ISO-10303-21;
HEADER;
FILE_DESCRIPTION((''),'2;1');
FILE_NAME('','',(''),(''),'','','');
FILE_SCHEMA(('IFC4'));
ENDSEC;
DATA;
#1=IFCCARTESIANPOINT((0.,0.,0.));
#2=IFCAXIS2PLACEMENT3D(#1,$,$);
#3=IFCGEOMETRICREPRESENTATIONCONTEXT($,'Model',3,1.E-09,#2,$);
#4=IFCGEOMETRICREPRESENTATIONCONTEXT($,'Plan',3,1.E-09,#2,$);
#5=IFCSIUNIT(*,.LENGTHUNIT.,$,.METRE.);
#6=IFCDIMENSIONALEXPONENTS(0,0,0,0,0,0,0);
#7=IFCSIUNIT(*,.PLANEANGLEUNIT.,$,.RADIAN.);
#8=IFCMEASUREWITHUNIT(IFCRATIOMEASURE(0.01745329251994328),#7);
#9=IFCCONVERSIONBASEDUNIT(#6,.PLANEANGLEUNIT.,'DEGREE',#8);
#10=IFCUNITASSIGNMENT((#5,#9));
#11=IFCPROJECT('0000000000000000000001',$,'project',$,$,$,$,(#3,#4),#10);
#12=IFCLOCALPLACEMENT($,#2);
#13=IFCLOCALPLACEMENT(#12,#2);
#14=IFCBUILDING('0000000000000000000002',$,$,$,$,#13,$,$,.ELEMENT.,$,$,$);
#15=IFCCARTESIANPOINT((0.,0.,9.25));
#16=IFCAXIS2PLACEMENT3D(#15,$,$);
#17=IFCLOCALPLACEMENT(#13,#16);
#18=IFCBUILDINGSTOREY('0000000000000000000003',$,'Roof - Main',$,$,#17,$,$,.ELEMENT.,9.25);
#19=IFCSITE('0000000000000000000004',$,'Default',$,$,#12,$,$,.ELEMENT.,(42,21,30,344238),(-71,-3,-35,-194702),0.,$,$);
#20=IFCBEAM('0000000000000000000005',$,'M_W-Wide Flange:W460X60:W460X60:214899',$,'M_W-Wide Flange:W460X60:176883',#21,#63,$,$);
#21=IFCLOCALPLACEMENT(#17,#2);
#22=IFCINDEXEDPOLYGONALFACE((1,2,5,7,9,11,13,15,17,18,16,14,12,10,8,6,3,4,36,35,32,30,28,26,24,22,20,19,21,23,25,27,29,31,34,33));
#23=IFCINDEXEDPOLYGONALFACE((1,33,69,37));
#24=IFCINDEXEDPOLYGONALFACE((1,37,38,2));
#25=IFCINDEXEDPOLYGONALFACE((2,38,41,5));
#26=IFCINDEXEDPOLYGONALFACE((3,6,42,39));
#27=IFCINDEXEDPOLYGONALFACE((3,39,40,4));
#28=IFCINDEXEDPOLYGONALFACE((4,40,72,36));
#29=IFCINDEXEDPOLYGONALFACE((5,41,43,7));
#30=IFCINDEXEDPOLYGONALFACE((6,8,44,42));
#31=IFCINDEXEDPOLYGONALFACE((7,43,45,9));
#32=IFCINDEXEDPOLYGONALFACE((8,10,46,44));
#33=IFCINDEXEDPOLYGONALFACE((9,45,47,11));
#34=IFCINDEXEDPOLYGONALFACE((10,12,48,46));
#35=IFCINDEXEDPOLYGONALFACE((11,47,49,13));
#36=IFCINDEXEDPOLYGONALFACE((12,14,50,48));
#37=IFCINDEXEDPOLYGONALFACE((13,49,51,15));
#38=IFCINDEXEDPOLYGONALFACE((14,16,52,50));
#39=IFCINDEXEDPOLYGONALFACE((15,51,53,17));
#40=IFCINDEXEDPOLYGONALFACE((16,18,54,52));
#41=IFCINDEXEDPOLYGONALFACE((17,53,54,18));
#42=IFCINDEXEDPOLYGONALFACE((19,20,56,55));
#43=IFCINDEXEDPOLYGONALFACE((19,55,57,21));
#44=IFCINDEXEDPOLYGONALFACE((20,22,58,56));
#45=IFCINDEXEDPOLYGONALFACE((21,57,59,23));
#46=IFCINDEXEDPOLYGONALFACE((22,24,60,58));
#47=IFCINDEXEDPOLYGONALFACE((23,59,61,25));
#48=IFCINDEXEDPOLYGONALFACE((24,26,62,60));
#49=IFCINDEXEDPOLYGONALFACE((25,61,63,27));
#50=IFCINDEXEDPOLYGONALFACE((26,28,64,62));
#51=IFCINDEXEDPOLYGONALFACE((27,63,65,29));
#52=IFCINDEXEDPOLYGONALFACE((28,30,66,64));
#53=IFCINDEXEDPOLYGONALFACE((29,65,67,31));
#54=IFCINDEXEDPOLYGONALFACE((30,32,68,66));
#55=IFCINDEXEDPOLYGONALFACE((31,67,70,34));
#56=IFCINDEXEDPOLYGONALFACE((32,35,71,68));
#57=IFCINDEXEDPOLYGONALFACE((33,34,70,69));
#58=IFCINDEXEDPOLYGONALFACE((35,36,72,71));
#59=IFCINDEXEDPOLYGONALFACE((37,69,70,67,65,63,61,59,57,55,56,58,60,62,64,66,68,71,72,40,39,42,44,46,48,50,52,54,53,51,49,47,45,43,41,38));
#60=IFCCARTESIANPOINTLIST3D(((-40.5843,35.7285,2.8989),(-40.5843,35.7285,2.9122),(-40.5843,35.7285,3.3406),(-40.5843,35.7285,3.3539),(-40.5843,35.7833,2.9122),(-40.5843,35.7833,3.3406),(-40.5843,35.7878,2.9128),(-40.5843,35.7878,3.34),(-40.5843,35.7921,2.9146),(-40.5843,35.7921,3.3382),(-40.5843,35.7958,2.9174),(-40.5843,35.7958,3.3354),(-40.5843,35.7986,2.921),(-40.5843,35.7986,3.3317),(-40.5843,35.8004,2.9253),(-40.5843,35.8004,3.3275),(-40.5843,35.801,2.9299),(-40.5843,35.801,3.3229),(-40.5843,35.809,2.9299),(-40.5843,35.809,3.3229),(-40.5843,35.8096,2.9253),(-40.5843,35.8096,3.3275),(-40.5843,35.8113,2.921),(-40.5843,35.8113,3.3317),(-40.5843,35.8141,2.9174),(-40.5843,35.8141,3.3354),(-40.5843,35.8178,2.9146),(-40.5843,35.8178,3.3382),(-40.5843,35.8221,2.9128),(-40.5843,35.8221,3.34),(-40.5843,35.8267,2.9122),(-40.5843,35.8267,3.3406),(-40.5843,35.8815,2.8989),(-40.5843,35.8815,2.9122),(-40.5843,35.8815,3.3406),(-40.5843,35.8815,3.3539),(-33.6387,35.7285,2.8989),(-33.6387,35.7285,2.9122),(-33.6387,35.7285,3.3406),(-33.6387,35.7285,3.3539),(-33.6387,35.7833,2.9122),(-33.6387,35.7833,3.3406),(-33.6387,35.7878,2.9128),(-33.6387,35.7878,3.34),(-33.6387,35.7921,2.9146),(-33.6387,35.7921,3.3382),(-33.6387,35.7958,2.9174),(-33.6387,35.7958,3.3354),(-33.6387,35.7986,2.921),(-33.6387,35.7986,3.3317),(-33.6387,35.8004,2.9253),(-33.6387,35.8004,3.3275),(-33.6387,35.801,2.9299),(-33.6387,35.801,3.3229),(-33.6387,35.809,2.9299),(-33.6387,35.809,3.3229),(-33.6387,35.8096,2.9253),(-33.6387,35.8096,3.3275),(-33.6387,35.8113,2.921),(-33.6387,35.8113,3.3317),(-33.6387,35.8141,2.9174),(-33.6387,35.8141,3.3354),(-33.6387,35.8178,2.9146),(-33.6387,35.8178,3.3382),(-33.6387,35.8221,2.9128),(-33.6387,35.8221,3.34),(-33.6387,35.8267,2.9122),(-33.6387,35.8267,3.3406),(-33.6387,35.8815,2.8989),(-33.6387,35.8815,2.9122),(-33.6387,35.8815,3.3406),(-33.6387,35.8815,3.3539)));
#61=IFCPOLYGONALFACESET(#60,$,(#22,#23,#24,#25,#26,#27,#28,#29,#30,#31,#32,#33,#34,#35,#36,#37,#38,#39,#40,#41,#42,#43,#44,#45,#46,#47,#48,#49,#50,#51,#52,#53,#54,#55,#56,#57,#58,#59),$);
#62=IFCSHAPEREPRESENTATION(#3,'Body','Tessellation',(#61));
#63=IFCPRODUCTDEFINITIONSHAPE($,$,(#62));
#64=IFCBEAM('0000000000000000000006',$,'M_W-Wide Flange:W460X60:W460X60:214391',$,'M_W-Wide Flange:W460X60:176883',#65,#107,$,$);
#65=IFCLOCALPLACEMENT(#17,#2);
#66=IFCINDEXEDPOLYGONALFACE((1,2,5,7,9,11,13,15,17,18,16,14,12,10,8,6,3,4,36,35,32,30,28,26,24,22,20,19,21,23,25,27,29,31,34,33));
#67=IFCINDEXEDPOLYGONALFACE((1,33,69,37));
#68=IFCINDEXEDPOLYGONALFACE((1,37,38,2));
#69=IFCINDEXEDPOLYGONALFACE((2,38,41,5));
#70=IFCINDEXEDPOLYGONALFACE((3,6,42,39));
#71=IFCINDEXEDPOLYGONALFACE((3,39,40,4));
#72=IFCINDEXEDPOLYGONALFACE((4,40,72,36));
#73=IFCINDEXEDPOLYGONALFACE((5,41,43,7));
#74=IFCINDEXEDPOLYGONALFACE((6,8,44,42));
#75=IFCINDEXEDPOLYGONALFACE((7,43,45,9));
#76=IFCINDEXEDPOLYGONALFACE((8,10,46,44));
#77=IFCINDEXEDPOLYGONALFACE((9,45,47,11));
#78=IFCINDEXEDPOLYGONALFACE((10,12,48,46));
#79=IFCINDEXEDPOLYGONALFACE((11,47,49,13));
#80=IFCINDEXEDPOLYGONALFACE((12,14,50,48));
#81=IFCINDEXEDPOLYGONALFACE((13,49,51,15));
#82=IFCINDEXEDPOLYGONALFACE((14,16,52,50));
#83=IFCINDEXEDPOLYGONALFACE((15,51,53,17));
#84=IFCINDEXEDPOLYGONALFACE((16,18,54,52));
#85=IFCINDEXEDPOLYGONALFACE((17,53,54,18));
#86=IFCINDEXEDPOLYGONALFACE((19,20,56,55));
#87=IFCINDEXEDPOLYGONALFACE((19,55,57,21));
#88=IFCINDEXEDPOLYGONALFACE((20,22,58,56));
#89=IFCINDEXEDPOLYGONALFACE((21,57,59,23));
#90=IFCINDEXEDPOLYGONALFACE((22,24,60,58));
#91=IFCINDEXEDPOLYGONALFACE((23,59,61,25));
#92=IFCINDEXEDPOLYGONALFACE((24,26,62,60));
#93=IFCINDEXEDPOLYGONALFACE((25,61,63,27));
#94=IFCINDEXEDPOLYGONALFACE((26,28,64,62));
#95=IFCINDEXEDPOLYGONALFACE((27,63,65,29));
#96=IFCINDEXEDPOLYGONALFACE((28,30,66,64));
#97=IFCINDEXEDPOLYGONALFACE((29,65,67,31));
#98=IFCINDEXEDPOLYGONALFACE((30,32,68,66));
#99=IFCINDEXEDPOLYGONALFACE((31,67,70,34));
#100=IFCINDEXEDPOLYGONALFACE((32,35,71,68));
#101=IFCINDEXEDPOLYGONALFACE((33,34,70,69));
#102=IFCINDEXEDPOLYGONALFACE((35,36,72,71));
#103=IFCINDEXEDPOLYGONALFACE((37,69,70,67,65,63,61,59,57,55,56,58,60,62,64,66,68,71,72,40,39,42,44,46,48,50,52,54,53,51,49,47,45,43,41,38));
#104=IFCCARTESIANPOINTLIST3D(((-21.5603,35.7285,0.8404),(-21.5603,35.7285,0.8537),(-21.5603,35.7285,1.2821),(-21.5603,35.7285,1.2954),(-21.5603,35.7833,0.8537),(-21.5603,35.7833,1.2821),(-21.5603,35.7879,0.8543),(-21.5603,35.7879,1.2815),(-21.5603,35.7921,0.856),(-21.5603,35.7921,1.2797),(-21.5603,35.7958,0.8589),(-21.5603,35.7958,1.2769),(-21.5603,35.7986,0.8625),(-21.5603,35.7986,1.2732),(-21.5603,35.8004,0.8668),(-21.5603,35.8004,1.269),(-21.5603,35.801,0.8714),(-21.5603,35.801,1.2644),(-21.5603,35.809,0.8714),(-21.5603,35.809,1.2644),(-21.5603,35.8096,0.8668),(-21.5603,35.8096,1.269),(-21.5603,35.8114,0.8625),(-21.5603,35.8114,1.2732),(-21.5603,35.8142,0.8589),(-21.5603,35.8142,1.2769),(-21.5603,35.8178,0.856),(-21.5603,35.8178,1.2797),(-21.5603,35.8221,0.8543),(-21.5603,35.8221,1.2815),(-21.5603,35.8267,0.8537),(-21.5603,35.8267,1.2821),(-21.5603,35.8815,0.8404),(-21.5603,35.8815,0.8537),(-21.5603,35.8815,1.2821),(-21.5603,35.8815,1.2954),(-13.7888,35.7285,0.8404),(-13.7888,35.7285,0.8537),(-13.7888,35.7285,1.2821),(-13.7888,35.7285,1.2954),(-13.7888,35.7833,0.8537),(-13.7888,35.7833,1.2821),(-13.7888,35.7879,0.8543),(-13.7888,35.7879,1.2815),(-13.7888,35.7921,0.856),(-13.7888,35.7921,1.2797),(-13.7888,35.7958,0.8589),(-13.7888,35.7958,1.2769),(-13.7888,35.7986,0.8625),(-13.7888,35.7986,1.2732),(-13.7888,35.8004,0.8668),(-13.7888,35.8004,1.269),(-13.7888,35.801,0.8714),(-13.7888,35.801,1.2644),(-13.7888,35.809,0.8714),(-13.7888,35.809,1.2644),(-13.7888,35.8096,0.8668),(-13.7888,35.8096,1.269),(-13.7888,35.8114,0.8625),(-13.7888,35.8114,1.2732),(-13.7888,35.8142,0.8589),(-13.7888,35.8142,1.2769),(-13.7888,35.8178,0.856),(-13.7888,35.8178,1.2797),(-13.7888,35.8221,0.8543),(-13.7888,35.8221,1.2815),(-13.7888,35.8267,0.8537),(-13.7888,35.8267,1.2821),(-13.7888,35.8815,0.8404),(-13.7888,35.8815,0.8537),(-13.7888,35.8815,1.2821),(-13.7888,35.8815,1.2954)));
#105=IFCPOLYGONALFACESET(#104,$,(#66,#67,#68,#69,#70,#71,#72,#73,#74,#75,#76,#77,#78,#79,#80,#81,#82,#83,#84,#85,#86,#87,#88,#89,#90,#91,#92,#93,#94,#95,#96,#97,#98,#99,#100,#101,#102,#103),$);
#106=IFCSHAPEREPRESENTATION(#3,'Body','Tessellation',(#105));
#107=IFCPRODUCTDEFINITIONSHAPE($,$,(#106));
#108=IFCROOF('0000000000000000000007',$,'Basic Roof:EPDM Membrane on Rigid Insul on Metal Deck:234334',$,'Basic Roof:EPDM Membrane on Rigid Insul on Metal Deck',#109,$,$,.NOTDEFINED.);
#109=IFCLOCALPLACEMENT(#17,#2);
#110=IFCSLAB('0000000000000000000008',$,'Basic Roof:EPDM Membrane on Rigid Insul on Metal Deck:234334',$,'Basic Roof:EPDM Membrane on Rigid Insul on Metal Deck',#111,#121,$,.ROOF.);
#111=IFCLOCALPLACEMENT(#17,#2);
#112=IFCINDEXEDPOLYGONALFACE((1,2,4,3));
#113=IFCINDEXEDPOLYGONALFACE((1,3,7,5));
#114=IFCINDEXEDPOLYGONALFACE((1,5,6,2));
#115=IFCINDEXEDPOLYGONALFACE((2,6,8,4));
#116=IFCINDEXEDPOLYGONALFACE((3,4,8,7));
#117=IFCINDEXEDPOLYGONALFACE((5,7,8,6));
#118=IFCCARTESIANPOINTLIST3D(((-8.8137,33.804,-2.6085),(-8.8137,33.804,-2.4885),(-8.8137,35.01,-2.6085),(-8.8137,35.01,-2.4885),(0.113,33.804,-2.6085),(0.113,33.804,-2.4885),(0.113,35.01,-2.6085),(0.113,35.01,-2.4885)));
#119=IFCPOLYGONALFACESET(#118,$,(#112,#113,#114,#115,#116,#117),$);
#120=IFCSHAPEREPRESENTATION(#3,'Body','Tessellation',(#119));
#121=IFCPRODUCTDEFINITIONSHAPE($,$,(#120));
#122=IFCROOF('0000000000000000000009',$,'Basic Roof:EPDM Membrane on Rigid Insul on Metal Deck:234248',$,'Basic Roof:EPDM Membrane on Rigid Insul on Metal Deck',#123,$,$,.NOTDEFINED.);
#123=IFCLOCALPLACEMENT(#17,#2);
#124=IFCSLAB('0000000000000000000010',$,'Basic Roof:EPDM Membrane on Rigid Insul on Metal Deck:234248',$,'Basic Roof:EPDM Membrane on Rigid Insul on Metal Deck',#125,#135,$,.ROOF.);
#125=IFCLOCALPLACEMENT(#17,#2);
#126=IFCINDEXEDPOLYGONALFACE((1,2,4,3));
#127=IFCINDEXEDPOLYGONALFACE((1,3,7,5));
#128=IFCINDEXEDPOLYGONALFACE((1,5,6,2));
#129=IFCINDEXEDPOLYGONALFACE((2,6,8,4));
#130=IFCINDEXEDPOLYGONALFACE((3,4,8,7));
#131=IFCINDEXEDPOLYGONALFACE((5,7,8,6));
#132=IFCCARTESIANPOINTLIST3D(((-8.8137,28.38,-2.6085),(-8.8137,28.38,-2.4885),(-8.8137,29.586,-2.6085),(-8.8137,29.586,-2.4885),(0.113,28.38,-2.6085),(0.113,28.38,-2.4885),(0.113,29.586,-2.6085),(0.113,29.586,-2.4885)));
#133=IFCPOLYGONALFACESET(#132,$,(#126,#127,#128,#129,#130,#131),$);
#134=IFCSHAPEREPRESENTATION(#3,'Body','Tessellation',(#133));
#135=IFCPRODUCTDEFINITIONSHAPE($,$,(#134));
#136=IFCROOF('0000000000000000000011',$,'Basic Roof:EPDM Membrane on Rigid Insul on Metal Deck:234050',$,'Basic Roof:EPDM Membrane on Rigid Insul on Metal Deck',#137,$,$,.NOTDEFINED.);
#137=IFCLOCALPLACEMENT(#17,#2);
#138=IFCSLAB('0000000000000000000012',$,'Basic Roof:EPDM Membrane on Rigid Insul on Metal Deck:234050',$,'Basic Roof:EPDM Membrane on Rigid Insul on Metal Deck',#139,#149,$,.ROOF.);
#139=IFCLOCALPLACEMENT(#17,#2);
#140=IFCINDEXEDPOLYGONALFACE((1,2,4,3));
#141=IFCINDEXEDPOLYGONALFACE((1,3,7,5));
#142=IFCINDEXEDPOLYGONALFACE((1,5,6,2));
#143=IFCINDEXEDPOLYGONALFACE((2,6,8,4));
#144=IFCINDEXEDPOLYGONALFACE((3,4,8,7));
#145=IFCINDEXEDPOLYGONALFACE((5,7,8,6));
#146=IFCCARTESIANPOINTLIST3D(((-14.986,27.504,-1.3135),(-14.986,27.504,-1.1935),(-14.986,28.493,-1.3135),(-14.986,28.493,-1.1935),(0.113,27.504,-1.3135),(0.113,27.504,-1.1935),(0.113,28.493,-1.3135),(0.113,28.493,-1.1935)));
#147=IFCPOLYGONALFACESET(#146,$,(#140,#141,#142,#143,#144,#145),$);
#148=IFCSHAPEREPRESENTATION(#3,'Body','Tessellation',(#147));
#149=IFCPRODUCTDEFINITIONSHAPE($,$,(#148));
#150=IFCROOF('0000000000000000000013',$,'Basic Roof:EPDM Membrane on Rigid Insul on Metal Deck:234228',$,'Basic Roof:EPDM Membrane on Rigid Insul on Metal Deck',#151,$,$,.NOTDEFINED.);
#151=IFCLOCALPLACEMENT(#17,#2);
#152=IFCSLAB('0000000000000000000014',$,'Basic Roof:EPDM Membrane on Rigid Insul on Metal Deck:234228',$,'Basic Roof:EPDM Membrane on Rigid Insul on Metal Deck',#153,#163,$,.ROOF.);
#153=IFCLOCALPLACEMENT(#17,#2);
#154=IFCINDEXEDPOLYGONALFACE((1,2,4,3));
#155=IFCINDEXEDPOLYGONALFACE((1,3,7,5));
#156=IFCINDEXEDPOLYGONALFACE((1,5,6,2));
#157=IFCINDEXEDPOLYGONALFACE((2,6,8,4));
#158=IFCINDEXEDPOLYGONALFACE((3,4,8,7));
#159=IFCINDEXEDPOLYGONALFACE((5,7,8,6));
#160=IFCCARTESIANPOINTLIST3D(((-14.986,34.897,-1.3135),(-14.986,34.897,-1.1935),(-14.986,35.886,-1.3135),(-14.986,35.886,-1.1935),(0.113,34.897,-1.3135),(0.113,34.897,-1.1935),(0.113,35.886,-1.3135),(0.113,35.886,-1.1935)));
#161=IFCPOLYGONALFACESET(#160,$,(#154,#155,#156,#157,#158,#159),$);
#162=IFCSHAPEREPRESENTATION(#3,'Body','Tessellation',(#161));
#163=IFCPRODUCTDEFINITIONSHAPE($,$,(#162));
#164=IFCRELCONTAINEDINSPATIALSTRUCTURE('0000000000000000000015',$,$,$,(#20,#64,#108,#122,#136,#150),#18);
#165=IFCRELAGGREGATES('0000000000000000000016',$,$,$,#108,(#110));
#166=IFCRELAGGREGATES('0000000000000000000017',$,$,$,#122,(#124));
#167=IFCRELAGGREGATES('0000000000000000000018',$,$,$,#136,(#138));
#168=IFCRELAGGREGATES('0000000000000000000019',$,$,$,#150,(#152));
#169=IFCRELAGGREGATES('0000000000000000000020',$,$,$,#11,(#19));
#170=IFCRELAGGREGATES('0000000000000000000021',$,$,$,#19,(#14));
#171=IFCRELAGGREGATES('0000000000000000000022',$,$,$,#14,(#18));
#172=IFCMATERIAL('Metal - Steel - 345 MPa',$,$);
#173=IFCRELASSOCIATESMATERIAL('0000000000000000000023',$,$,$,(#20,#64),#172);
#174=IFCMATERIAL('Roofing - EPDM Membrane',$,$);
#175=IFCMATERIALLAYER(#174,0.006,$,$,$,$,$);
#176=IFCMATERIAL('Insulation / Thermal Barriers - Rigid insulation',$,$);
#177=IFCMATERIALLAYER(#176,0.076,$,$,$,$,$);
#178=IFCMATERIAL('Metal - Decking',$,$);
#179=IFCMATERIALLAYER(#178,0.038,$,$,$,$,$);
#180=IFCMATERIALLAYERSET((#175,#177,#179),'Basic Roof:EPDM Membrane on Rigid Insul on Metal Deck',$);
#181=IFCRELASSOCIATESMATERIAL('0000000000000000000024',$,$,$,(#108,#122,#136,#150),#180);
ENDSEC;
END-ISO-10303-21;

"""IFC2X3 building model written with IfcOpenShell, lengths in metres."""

from ifc_helpers import new_model, entity, si_unit, converted_unit, frame, frame_2d, origin, origin_2d_with_axis, place, context, project, spatial, polyline, circle_curve, parameter, trimmed, segment, composite_curve, rectangle, outline, extrude, material, layer, layer_set, layer_usage, element, aggregate, save


model = new_model("IFC2X3")

# Units and contexts
model_context = context("Model", 3, precision=1e-09, world=origin())
plan_context = context("Plan", 3, precision=1e-09, world=origin())
ifc_project = project(units=[si_unit("LENGTHUNIT", "METRE"), converted_unit("PLANEANGLEUNIT", "DEGREE", entity("IfcRatioMeasure", 0.01745329251994328), si_unit("PLANEANGLEUNIT", "RADIAN"), dimensions=[0, 0, 0, 0, 0, 0, 0])], contexts=[model_context, plan_context])

# Site, building, storey
site_placement = place(None, origin())
site = spatial("IfcSite", under=ifc_project, at=site_placement, Name="Default", CompositionType="ELEMENT", RefLatitude=(42, 21, 30, 344238), RefLongitude=(-71, -3, -35, -194702), RefElevation=0.0)
building_placement = place(site_placement, origin())
building = spatial("IfcBuilding", under=site, at=building_placement, CompositionType="ELEMENT")
storey_placement = place(building_placement, frame((0.0, 0.0, 9.25)))
storey = spatial("IfcBuildingStorey", under=building, at=storey_placement, Name="Roof - Main", CompositionType="ELEMENT", Elevation=9.25)

# Shared definitions
ifc_material_1 = material(Name="Metal - Steel - 345 MPa")

# Beams
beam_1_placement = place(storey_placement, frame((-6.691, 35.805, 3.3539), z_axis=(0.0, 0.0, 1.0), x_axis=(0.0, -1.0, 0.0)))
element("IfcBeam", 1, at=beam_1_placement, inside=storey, material=ifc_material_1, Name="M_W-Wide Flange:W460X60:W460X60:214899", ObjectType="M_W-Wide Flange:W460X60:176883", context=model_context, shape_type="SweptSolid", body=[
    extrude(outline(composite_curve([segment(polyline([(-0.0765, -0.2142), (-0.0765, -0.2275)]), True, "CONTINUOUS"), segment(polyline([(-0.0765, -0.2275), (0.0765, -0.2275)]), True, "CONTINUOUS"), segment(polyline([(0.0765, -0.2275), (0.0765, -0.2142)]), True, "CONTINUOUS"), segment(polyline([(0.0765, -0.2142), (0.0217, -0.2142)]), True, "CONTINUOUS"), segment(trimmed(circle_curve(frame_2d((0.0217, -0.1965), x_axis=(1.0, 0.0)), 0.0177), [parameter(180.0)], [parameter(270.0)], True, "PARAMETER"), False, "CONTINUOUS"), segment(polyline([(0.004, -0.1965), (0.004, 0.1965)]), True, "CONTINUOUS"), segment(trimmed(circle_curve(frame_2d((0.0217, 0.1965), x_axis=(1.0, 0.0)), 0.0177), [parameter(90.0)], [parameter(180.0)], True, "PARAMETER"), False, "CONTINUOUS"), segment(polyline([(0.0217, 0.2142), (0.0765, 0.2142)]), True, "CONTINUOUS"), segment(polyline([(0.0765, 0.2142), (0.0765, 0.2275)]), True, "CONTINUOUS"), segment(polyline([(0.0765, 0.2275), (-0.0765, 0.2275)]), True, "CONTINUOUS"), segment(polyline([(-0.0765, 0.2275), (-0.0765, 0.2142)]), True, "CONTINUOUS"), segment(polyline([(-0.0765, 0.2142), (-0.0217, 0.2142)]), True, "CONTINUOUS"), segment(trimmed(circle_curve(frame_2d((-0.0217, 0.1965), x_axis=(1.0, 0.0)), 0.0177), [parameter(360.0)], [parameter(90.0)], True, "PARAMETER"), False, "CONTINUOUS"), segment(polyline([(-0.004, 0.1965), (-0.004, -0.1965)]), True, "CONTINUOUS"), segment(trimmed(circle_curve(frame_2d((-0.0217, -0.1965), x_axis=(1.0, 0.0)), 0.0177), [parameter(270.0)], [parameter(0.0)], True, "PARAMETER"), False, "CONTINUOUS"), segment(polyline([(-0.0217, -0.2142), (-0.0765, -0.2142)]), True, "CONTINUOUS")], self_intersect=False)), frame((0.0, -33.8933, -0.2275), z_axis=(0.0, -1.0, 0.0), x_axis=(1.0, 0.0, 0.0)), (0.0, 0.0, -1.0), 6.9456),
])
beam_2_placement = place(storey_placement, frame((-7.2776, 35.805, 1.2954), z_axis=(0.0, 0.0, 1.0), x_axis=(0.0, -1.0, 0.0)))
element("IfcBeam", 2, at=beam_2_placement, inside=storey, material=ifc_material_1, Name="M_W-Wide Flange:W460X60:W460X60:214391", ObjectType="M_W-Wide Flange:W460X60:176883", context=model_context, shape_type="SweptSolid", body=[
    extrude(outline(composite_curve([segment(polyline([(-0.0765, -0.2142), (-0.0765, -0.2275)]), True, "CONTINUOUS"), segment(polyline([(-0.0765, -0.2275), (0.0765, -0.2275)]), True, "CONTINUOUS"), segment(polyline([(0.0765, -0.2275), (0.0765, -0.2142)]), True, "CONTINUOUS"), segment(polyline([(0.0765, -0.2142), (0.0217, -0.2142)]), True, "CONTINUOUS"), segment(trimmed(circle_curve(frame_2d((0.0217, -0.1965), x_axis=(1.0, 0.0)), 0.0177), [parameter(180.0)], [parameter(270.0)], True, "PARAMETER"), False, "CONTINUOUS"), segment(polyline([(0.004, -0.1965), (0.004, 0.1965)]), True, "CONTINUOUS"), segment(trimmed(circle_curve(frame_2d((0.0217, 0.1965), x_axis=(1.0, 0.0)), 0.0177), [parameter(90.0)], [parameter(180.0)], True, "PARAMETER"), False, "CONTINUOUS"), segment(polyline([(0.0217, 0.2142), (0.0765, 0.2142)]), True, "CONTINUOUS"), segment(polyline([(0.0765, 0.2142), (0.0765, 0.2275)]), True, "CONTINUOUS"), segment(polyline([(0.0765, 0.2275), (-0.0765, 0.2275)]), True, "CONTINUOUS"), segment(polyline([(-0.0765, 0.2275), (-0.0765, 0.2142)]), True, "CONTINUOUS"), segment(polyline([(-0.0765, 0.2142), (-0.0217, 0.2142)]), True, "CONTINUOUS"), segment(trimmed(circle_curve(frame_2d((-0.0217, 0.1965), x_axis=(1.0, 0.0)), 0.0177), [parameter(360.0)], [parameter(90.0)], True, "PARAMETER"), False, "CONTINUOUS"), segment(polyline([(-0.004, 0.1965), (-0.004, -0.1965)]), True, "CONTINUOUS"), segment(trimmed(circle_curve(frame_2d((-0.0217, -0.1965), x_axis=(1.0, 0.0)), 0.0177), [parameter(270.0)], [parameter(0.0)], True, "PARAMETER"), False, "CONTINUOUS"), segment(polyline([(-0.0217, -0.2142), (-0.0765, -0.2142)]), True, "CONTINUOUS")], self_intersect=False)), frame((0.0, -14.2827, -0.2275), z_axis=(0.0, -1.0, 0.0), x_axis=(1.0, 0.0, 0.0)), (0.0, 0.0, -1.0), 7.7715),
])

# Shared definitions
ifc_material_2 = material(Name="Metal - Decking")
ifc_layer_1 = layer(ifc_material_2, 0.038)

# Roofs, slabs
ifc_material_3 = material(Name="Roofing - EPDM Membrane")
ifc_layer_2 = layer(ifc_material_3, 0.006)
ifc_material_4 = material(Name="Insulation / Thermal Barriers - Rigid insulation")
ifc_layer_3 = layer(ifc_material_4, 0.076)
ifc_layer_set_1 = layer_set([ifc_layer_2, ifc_layer_3, ifc_layer_1], Name="Basic Roof:EPDM Membrane on Rigid Insul on Metal Deck")
ifc_layer_usage_1 = layer_usage(ifc_layer_set_1, "AXIS3", "NEGATIVE", 0.0)
roof_1_placement = place(storey_placement, origin())
roof_1 = element("IfcRoof", 3, at=roof_1_placement, inside=storey, material=ifc_layer_usage_1, Name="Basic Roof:EPDM Membrane on Rigid Insul on Metal Deck:234334", ObjectType="Basic Roof:EPDM Membrane on Rigid Insul on Metal Deck", ShapeType="NOTDEFINED")
slab_1_placement = place(roof_1_placement, frame((-8.8137, 33.804, -2.6085)))
slab_1 = element("IfcSlab", 4, at=slab_1_placement, Name="Basic Roof:EPDM Membrane on Rigid Insul on Metal Deck:234334", ObjectType="Basic Roof:EPDM Membrane on Rigid Insul on Metal Deck", PredefinedType="ROOF", context=model_context, shape_type="SweptSolid", body=[
    extrude(rectangle(XDim=8.9267, YDim=1.206, at=frame_2d((0.0, 0.0), x_axis=(-1.0, 0.0))), frame((4.4634, 0.603, 0.0)), (0.0, 0.0, 1.0), 0.12),
])
aggregate(roof_1, [slab_1])
roof_2_placement = place(storey_placement, origin())
roof_2 = element("IfcRoof", 5, at=roof_2_placement, inside=storey, material=ifc_layer_usage_1, Name="Basic Roof:EPDM Membrane on Rigid Insul on Metal Deck:234248", ObjectType="Basic Roof:EPDM Membrane on Rigid Insul on Metal Deck", ShapeType="NOTDEFINED")
slab_2_placement = place(roof_2_placement, frame((-8.8137, 28.38, -2.6085)))
slab_2 = element("IfcSlab", 6, at=slab_2_placement, Name="Basic Roof:EPDM Membrane on Rigid Insul on Metal Deck:234248", ObjectType="Basic Roof:EPDM Membrane on Rigid Insul on Metal Deck", PredefinedType="ROOF", context=model_context, shape_type="SweptSolid", body=[
    extrude(rectangle(XDim=8.9267, YDim=1.206, at=origin_2d_with_axis()), frame((4.4634, 0.603, 0.0)), (0.0, 0.0, 1.0), 0.12),
])
aggregate(roof_2, [slab_2])
roof_3_placement = place(storey_placement, origin())
roof_3 = element("IfcRoof", 7, at=roof_3_placement, inside=storey, material=ifc_layer_usage_1, Name="Basic Roof:EPDM Membrane on Rigid Insul on Metal Deck:234050", ObjectType="Basic Roof:EPDM Membrane on Rigid Insul on Metal Deck", ShapeType="NOTDEFINED")
slab_3_placement = place(roof_3_placement, frame((-14.986, 27.504, -1.3135)))
slab_3 = element("IfcSlab", 8, at=slab_3_placement, Name="Basic Roof:EPDM Membrane on Rigid Insul on Metal Deck:234050", ObjectType="Basic Roof:EPDM Membrane on Rigid Insul on Metal Deck", PredefinedType="ROOF", context=model_context, shape_type="SweptSolid", body=[
    extrude(rectangle(XDim=15.099, YDim=0.989, at=origin_2d_with_axis()), frame((7.5495, 0.4945, 0.0)), (0.0, 0.0, 1.0), 0.12),
])
aggregate(roof_3, [slab_3])
roof_4_placement = place(storey_placement, origin())
roof_4 = element("IfcRoof", 9, at=roof_4_placement, inside=storey, material=ifc_layer_usage_1, Name="Basic Roof:EPDM Membrane on Rigid Insul on Metal Deck:234228", ObjectType="Basic Roof:EPDM Membrane on Rigid Insul on Metal Deck", ShapeType="NOTDEFINED")
slab_4_placement = place(roof_4_placement, frame((-14.986, 34.897, -1.3135)))
slab_4 = element("IfcSlab", 10, at=slab_4_placement, Name="Basic Roof:EPDM Membrane on Rigid Insul on Metal Deck:234228", ObjectType="Basic Roof:EPDM Membrane on Rigid Insul on Metal Deck", PredefinedType="ROOF", context=model_context, shape_type="SweptSolid", body=[
    extrude(rectangle(XDim=15.099, YDim=0.989, at=frame_2d((0.0, 0.0), x_axis=(-1.0, 0.0))), frame((7.5495, 0.4945, 0.0)), (0.0, 0.0, 1.0), 0.12),
])
aggregate(roof_4, [slab_4])

save(model, "model.ifc")
